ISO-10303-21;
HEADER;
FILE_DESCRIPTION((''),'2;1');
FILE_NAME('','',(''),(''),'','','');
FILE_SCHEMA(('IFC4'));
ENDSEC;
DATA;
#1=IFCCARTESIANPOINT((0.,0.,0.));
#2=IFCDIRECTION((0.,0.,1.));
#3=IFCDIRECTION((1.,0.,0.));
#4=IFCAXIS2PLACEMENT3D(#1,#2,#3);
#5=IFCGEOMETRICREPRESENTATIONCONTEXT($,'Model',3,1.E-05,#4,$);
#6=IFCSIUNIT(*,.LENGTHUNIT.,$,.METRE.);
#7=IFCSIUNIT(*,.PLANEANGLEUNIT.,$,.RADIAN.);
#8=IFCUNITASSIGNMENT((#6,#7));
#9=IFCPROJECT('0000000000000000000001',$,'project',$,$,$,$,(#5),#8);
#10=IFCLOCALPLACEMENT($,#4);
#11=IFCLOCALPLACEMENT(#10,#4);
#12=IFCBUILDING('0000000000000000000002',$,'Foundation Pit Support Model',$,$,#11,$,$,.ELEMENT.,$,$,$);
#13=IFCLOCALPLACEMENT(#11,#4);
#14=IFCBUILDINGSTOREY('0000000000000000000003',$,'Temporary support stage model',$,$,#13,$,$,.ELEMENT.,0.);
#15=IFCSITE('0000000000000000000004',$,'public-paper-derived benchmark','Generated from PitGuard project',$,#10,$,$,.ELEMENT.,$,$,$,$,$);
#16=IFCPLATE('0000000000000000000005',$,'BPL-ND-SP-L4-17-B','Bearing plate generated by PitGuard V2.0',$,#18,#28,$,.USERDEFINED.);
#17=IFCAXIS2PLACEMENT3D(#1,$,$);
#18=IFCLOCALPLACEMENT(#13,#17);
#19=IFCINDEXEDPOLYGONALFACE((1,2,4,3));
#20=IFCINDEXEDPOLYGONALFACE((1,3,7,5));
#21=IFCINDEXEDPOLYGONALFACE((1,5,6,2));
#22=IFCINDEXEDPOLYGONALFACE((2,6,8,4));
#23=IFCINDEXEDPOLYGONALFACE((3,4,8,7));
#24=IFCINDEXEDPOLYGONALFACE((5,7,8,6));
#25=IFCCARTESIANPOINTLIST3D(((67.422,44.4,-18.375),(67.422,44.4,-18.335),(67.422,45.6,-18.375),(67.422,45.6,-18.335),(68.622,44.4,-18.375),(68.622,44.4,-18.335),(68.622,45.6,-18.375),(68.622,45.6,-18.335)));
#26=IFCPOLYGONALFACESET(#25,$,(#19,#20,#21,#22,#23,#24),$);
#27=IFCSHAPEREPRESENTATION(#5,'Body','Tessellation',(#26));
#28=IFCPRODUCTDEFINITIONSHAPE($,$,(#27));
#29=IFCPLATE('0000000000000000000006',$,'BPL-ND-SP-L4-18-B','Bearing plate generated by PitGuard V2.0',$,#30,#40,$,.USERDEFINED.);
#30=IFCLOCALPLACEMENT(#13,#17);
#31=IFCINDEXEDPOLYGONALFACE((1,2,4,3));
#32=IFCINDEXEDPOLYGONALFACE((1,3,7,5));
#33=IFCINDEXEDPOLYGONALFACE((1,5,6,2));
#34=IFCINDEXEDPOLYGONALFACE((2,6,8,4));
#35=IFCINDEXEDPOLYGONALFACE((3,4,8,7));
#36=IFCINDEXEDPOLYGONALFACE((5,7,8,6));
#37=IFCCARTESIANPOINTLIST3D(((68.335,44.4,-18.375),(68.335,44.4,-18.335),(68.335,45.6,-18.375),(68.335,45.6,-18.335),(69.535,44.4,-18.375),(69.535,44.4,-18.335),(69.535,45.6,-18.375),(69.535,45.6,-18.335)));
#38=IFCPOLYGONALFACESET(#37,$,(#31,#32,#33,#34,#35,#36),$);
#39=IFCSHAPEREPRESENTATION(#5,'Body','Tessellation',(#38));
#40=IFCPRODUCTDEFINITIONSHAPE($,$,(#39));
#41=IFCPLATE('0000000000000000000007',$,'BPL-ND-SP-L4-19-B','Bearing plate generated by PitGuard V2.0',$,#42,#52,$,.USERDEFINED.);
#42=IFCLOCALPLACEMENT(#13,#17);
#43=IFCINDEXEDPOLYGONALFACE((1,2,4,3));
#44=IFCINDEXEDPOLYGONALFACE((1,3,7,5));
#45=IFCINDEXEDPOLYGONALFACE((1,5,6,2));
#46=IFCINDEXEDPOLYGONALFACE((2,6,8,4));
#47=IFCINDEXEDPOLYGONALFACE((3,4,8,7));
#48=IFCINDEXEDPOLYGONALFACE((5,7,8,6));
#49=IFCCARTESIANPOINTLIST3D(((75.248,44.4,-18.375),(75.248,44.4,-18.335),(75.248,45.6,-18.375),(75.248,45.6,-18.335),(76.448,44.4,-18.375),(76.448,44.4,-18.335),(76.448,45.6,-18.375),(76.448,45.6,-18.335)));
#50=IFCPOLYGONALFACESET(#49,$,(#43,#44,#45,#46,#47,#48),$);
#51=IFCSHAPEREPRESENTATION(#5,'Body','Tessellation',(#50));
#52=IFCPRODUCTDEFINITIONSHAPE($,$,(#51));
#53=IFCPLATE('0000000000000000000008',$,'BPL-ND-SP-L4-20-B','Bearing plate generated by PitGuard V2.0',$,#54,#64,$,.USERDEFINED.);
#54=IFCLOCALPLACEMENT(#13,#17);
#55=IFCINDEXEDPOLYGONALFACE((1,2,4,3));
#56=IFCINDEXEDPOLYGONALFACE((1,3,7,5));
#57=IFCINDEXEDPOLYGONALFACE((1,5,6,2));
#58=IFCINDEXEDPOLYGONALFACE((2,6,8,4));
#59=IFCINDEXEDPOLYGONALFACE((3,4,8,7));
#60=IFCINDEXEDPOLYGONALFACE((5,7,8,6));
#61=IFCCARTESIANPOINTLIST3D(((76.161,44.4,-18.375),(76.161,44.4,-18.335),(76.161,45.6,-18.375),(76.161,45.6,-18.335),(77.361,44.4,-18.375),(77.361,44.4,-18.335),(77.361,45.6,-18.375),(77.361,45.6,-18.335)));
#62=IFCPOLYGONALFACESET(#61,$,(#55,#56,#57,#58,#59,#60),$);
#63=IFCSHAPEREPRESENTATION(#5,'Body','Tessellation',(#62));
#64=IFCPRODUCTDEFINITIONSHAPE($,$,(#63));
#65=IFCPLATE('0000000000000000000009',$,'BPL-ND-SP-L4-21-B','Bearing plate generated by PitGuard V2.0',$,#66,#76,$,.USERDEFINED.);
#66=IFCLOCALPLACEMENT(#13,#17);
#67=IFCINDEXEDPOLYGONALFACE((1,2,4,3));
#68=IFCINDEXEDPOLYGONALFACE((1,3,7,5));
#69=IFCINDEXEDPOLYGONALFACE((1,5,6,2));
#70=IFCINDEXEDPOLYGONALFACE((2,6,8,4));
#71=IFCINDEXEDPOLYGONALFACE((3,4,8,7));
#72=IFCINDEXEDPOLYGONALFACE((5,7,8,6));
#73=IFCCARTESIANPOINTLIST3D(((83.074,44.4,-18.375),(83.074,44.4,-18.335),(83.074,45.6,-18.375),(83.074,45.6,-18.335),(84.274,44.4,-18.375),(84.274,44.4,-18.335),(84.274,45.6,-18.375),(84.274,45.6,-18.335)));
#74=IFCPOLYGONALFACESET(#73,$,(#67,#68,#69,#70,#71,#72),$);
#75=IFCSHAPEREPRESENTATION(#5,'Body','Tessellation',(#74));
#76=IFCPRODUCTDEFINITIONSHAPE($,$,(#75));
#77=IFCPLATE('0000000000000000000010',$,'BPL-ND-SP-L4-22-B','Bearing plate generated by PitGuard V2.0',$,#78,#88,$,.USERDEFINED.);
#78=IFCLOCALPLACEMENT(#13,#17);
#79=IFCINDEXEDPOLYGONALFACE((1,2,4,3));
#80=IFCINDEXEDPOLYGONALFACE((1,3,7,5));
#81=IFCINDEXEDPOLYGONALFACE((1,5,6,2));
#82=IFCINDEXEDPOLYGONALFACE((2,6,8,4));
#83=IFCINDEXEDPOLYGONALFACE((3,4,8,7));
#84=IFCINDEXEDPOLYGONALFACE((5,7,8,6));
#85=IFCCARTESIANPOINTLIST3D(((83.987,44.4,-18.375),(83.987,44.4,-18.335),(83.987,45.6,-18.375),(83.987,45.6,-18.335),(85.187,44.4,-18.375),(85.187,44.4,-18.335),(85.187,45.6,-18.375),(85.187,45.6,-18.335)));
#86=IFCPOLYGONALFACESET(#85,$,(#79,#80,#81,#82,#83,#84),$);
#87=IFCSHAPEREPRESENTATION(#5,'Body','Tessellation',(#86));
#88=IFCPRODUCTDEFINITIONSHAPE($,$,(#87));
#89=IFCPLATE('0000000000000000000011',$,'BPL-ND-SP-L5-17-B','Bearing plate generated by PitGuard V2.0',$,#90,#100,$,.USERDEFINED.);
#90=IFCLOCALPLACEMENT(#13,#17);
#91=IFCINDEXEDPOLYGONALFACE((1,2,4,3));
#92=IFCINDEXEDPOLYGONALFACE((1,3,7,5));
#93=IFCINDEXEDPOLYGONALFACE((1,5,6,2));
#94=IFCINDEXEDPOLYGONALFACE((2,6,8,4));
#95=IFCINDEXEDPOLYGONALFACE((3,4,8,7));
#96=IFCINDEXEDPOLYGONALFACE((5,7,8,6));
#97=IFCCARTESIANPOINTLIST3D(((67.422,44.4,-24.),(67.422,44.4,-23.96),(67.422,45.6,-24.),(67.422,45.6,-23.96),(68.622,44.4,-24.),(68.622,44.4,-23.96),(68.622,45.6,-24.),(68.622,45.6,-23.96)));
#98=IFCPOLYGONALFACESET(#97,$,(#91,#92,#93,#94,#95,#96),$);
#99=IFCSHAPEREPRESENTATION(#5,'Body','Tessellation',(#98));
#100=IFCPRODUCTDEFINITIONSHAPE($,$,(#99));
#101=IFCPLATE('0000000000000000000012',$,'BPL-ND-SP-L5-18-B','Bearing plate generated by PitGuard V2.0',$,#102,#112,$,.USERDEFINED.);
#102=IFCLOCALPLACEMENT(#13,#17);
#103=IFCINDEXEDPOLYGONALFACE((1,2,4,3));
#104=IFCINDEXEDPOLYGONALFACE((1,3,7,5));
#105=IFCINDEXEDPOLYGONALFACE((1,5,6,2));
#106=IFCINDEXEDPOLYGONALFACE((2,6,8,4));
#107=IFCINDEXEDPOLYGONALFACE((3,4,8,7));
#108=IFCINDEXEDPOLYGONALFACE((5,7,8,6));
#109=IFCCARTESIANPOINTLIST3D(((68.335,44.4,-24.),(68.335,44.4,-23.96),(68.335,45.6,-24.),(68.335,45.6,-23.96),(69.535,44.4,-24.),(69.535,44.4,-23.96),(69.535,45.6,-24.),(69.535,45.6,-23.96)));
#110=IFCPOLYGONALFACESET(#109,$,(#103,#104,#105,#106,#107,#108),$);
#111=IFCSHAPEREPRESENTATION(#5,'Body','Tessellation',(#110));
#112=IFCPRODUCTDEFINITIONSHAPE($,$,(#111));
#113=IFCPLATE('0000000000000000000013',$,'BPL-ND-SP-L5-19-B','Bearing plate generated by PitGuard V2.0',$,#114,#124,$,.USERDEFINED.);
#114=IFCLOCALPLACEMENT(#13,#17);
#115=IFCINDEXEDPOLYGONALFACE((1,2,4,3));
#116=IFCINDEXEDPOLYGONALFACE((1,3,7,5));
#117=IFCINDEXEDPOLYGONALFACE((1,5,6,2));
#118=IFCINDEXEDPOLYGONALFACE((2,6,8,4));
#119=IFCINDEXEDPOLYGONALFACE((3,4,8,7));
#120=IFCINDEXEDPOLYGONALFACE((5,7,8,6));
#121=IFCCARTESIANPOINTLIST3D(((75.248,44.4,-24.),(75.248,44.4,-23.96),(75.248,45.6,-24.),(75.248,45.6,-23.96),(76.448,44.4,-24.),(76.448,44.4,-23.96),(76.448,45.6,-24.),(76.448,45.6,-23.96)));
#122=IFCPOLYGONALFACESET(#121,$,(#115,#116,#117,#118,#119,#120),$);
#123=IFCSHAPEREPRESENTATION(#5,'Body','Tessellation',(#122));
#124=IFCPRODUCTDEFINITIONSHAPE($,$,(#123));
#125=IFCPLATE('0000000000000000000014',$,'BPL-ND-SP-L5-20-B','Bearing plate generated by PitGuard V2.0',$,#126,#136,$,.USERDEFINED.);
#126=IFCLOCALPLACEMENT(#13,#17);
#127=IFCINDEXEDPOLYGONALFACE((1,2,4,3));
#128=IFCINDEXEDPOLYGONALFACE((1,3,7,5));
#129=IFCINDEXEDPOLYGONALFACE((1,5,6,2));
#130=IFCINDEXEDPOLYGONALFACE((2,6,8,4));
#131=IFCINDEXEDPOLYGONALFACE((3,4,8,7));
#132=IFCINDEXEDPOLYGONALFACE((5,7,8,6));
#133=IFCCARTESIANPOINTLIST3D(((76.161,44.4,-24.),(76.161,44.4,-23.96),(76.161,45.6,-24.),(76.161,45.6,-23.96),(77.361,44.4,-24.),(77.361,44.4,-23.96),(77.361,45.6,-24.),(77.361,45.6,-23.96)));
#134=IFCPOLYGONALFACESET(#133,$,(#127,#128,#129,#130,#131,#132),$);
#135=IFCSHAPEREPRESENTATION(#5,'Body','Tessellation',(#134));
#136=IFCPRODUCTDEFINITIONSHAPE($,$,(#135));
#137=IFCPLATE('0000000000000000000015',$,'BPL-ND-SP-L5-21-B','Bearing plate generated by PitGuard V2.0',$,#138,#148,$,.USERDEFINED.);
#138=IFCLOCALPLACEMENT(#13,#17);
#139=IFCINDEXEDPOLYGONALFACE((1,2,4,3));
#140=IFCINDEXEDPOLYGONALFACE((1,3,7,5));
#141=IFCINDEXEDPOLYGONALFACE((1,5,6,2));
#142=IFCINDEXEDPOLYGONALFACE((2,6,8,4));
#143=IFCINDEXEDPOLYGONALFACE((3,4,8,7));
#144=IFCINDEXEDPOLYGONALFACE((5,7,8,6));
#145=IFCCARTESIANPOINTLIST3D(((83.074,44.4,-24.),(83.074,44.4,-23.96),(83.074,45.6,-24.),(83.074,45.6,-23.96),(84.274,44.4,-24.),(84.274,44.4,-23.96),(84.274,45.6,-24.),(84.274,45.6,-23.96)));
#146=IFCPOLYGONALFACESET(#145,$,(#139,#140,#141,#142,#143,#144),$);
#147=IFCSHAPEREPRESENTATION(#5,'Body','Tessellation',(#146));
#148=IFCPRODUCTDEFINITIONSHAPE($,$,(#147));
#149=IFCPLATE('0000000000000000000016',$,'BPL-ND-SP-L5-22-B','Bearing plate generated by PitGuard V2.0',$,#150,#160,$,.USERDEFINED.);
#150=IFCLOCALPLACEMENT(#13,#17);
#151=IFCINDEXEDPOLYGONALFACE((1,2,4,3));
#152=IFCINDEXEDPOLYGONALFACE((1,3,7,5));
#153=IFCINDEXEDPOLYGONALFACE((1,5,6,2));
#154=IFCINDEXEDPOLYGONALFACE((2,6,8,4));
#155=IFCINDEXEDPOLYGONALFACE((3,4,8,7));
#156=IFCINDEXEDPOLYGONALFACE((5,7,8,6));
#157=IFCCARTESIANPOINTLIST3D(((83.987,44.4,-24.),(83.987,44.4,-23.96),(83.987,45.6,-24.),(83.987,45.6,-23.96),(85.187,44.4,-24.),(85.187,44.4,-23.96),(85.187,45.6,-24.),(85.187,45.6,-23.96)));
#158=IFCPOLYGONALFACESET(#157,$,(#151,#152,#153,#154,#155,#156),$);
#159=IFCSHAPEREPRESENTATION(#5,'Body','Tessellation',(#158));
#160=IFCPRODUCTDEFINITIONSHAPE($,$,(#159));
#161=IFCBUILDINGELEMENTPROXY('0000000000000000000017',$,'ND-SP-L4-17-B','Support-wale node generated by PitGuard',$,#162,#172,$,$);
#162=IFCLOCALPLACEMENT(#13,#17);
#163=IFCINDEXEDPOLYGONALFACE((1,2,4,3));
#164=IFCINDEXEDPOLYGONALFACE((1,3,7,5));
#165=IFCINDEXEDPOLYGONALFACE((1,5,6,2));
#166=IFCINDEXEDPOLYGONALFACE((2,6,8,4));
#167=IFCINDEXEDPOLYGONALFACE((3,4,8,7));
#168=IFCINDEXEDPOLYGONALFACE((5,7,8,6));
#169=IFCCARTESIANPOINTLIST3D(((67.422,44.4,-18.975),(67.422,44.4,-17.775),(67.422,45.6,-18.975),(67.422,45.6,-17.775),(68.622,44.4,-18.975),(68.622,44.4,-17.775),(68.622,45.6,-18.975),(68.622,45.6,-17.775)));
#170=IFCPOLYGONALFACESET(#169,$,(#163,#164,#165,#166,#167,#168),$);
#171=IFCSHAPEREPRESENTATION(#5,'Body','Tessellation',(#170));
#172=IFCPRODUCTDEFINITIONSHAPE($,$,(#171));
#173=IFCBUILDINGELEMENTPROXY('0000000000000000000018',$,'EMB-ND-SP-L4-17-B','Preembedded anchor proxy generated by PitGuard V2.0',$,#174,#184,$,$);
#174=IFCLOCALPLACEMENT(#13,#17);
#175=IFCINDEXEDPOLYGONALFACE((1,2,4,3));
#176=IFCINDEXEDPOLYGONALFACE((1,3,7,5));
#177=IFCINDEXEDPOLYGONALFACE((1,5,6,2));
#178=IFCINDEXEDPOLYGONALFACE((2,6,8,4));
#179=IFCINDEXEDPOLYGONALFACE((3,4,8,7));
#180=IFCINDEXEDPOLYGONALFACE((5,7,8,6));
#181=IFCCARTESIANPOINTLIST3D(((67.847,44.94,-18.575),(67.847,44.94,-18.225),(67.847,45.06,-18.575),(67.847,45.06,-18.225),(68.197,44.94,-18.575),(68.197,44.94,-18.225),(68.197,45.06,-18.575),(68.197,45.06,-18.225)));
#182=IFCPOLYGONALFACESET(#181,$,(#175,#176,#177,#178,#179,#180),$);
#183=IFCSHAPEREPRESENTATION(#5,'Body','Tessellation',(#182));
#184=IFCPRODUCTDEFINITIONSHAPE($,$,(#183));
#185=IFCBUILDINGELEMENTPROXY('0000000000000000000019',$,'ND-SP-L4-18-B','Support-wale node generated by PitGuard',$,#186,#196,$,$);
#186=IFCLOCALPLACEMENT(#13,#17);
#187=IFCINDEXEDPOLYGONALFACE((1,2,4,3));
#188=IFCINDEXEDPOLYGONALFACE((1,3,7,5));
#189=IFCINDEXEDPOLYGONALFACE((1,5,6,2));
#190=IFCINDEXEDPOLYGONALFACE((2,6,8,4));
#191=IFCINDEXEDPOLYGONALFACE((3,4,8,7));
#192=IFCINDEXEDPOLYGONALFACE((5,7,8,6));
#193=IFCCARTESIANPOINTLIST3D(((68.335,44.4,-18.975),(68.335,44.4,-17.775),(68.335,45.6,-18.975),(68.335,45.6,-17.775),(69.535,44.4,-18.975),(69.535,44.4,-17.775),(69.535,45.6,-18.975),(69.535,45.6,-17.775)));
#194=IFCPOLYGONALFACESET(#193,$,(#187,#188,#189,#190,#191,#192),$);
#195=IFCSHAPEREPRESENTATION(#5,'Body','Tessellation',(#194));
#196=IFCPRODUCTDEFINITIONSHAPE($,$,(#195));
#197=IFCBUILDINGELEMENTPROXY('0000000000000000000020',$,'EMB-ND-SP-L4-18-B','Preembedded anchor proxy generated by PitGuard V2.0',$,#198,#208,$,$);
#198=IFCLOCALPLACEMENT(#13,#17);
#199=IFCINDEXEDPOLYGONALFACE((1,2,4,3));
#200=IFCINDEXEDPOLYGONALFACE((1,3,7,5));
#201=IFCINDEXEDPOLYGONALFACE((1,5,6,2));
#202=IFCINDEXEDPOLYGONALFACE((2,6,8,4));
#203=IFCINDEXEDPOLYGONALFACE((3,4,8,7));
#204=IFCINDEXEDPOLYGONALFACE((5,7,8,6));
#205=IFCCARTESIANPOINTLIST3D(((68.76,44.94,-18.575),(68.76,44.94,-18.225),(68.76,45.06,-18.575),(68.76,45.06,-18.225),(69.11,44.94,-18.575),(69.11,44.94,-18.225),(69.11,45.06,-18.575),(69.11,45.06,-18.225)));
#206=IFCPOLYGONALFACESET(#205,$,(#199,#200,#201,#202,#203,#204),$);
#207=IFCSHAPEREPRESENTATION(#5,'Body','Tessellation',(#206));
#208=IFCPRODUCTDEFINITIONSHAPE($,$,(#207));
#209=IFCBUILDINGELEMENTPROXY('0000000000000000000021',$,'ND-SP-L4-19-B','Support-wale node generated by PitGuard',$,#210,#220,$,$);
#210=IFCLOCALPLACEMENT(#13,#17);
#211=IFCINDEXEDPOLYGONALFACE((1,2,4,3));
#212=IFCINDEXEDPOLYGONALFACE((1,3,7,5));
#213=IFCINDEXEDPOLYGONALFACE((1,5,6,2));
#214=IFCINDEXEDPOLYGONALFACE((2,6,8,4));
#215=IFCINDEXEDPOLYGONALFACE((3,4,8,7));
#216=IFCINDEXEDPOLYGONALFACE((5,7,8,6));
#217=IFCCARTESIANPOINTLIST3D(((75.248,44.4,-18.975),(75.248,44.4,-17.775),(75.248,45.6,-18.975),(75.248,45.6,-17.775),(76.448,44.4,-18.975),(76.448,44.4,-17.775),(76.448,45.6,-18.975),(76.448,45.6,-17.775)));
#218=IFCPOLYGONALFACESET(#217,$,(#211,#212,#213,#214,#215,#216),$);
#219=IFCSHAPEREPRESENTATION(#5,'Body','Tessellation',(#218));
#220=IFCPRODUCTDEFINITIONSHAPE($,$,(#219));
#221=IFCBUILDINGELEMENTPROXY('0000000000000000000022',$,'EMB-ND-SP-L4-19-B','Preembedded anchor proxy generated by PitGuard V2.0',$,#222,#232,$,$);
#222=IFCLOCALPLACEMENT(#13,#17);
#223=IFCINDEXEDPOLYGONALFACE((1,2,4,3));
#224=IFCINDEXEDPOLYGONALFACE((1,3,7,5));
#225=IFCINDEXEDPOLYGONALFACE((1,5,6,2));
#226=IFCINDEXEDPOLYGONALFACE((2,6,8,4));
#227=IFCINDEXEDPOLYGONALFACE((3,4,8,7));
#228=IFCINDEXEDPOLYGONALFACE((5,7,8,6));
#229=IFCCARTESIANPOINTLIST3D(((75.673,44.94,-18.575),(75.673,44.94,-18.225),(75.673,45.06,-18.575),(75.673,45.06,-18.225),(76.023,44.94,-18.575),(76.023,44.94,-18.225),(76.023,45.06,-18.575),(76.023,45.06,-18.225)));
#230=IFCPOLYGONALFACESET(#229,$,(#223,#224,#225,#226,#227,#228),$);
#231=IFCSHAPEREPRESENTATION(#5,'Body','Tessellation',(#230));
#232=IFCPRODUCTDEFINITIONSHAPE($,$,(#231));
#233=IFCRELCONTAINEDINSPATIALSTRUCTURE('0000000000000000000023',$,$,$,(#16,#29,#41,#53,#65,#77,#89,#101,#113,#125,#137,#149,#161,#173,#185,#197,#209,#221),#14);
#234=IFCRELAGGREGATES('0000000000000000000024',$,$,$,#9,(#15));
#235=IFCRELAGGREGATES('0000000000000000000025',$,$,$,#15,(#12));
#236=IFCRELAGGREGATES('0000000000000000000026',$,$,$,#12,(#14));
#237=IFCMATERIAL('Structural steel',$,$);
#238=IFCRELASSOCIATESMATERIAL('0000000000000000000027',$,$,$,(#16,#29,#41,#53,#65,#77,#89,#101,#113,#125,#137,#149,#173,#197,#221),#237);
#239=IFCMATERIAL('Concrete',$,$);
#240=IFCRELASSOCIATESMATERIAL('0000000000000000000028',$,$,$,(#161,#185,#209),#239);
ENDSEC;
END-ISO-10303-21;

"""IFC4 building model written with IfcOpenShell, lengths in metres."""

from ifc_helpers import new_model, si_unit, frame, origin_with_axes, origin_2d, place, context, project, spatial, rectangle, extrude, material, element, save


model = new_model("IFC4")

# Units and contexts
model_context = context("Model", 3, precision=1e-05, world=origin_with_axes())
ifc_project = project(units=[si_unit("LENGTHUNIT", "METRE"), si_unit("PLANEANGLEUNIT", "RADIAN")], contexts=[model_context])

# Site, building, storey
site_placement = place(None, origin_with_axes())
site = spatial("IfcSite", under=ifc_project, at=site_placement, Name="public-paper-derived benchmark", Description="Generated from PitGuard project", CompositionType="ELEMENT")
building_placement = place(site_placement, origin_with_axes())
building = spatial("IfcBuilding", under=site, at=building_placement, Name="Foundation Pit Support Model", CompositionType="ELEMENT")
storey_placement = place(building_placement, origin_with_axes())
storey = spatial("IfcBuildingStorey", under=building, at=storey_placement, Name="Temporary support stage model", CompositionType="ELEMENT", Elevation=0.0)

# Plates
ifc_material_1 = material(Name="Structural steel")
for number, where, z_axis, x_axis, name in (
    (1, (68.022, 45.0, -18.375), (0.0, 0.0, 1.0), (1.0, 0.0, 0.0), "BPL-ND-SP-L4-17-B"),
    (2, (68.935, 45.0, -18.375), (0.0, 0.0, 1.0), (1.0, 0.0, 0.0), "BPL-ND-SP-L4-18-B"),
    (3, (75.848, 45.0, -18.375), (0.0, 0.0, 1.0), (1.0, 0.0, 0.0), "BPL-ND-SP-L4-19-B"),
    (4, (76.761, 45.0, -18.375), (0.0, 0.0, 1.0), (1.0, 0.0, 0.0), "BPL-ND-SP-L4-20-B"),
    (5, (83.674, 45.0, -18.375), (0.0, 0.0, 1.0), (1.0, 0.0, 0.0), "BPL-ND-SP-L4-21-B"),
    (6, (84.587, 45.0, -18.375), (0.0, 0.0, 1.0), (1.0, 0.0, 0.0), "BPL-ND-SP-L4-22-B"),
    (7, (68.022, 45.0, -24.0), (0.0, 0.0, 1.0), (1.0, 0.0, 0.0), "BPL-ND-SP-L5-17-B"),
    (8, (68.935, 45.0, -24.0), (0.0, 0.0, 1.0), (1.0, 0.0, 0.0), "BPL-ND-SP-L5-18-B"),
    (9, (75.848, 45.0, -24.0), (0.0, 0.0, 1.0), (1.0, 0.0, 0.0), "BPL-ND-SP-L5-19-B"),
    (10, (76.761, 45.0, -24.0), (0.0, 0.0, 1.0), (1.0, 0.0, 0.0), "BPL-ND-SP-L5-20-B"),
    (11, (83.674, 45.0, -24.0), (0.0, 0.0, 1.0), (1.0, 0.0, 0.0), "BPL-ND-SP-L5-21-B"),
    (12, (84.587, 45.0, -24.0), (0.0, 0.0, 1.0), (1.0, 0.0, 0.0), "BPL-ND-SP-L5-22-B"),
):
    element("IfcPlate", number, at=place(storey_placement, frame(where, z_axis=z_axis, x_axis=x_axis)), inside=storey, material=ifc_material_1, Name=name, Description="Bearing plate generated by PitGuard V2.0", PredefinedType="USERDEFINED", context=model_context, shape_type="SweptSolid", body=[
        extrude(rectangle(XDim=1.2, YDim=1.2, at=origin_2d()), origin_with_axes(), (0.0, 0.0, 1.0), 0.04),
    ])

# Building element proxies
ifc_material_2 = material(Name="Concrete")
proxy_1_placement = place(storey_placement, frame((68.022, 45.0, -18.975), z_axis=(0.0, 0.0, 1.0), x_axis=(1.0, 0.0, 0.0)))
element("IfcBuildingElementProxy", 13, at=proxy_1_placement, inside=storey, material=ifc_material_2, Name="ND-SP-L4-17-B", Description="Support-wale node generated by PitGuard", context=model_context, shape_type="SweptSolid", body=[
    extrude(rectangle(XDim=1.2, YDim=1.2, at=origin_2d()), origin_with_axes(), (0.0, 0.0, 1.0), 1.2),
])
proxy_2_placement = place(storey_placement, frame((68.022, 45.0, -18.575), z_axis=(0.0, 0.0, 1.0), x_axis=(1.0, 0.0, 0.0)))
element("IfcBuildingElementProxy", 14, at=proxy_2_placement, inside=storey, material=ifc_material_1, Name="EMB-ND-SP-L4-17-B", Description="Preembedded anchor proxy generated by PitGuard V2.0", context=model_context, shape_type="SweptSolid", body=[
    extrude(rectangle(XDim=0.35, YDim=0.12, at=origin_2d()), origin_with_axes(), (0.0, 0.0, 1.0), 0.35),
])
proxy_3_placement = place(storey_placement, frame((68.935, 45.0, -18.975), z_axis=(0.0, 0.0, 1.0), x_axis=(1.0, 0.0, 0.0)))
element("IfcBuildingElementProxy", 15, at=proxy_3_placement, inside=storey, material=ifc_material_2, Name="ND-SP-L4-18-B", Description="Support-wale node generated by PitGuard", context=model_context, shape_type="SweptSolid", body=[
    extrude(rectangle(XDim=1.2, YDim=1.2, at=origin_2d()), origin_with_axes(), (0.0, 0.0, 1.0), 1.2),
])
proxy_4_placement = place(storey_placement, frame((68.935, 45.0, -18.575), z_axis=(0.0, 0.0, 1.0), x_axis=(1.0, 0.0, 0.0)))
element("IfcBuildingElementProxy", 16, at=proxy_4_placement, inside=storey, material=ifc_material_1, Name="EMB-ND-SP-L4-18-B", Description="Preembedded anchor proxy generated by PitGuard V2.0", context=model_context, shape_type="SweptSolid", body=[
    extrude(rectangle(XDim=0.35, YDim=0.12, at=origin_2d()), origin_with_axes(), (0.0, 0.0, 1.0), 0.35),
])
proxy_5_placement = place(storey_placement, frame((75.848, 45.0, -18.975), z_axis=(0.0, 0.0, 1.0), x_axis=(1.0, 0.0, 0.0)))
element("IfcBuildingElementProxy", 17, at=proxy_5_placement, inside=storey, material=ifc_material_2, Name="ND-SP-L4-19-B", Description="Support-wale node generated by PitGuard", context=model_context, shape_type="SweptSolid", body=[
    extrude(rectangle(XDim=1.2, YDim=1.2, at=origin_2d()), origin_with_axes(), (0.0, 0.0, 1.0), 1.2),
])
proxy_6_placement = place(storey_placement, frame((75.848, 45.0, -18.575), z_axis=(0.0, 0.0, 1.0), x_axis=(1.0, 0.0, 0.0)))
element("IfcBuildingElementProxy", 18, at=proxy_6_placement, inside=storey, material=ifc_material_1, Name="EMB-ND-SP-L4-19-B", Description="Preembedded anchor proxy generated by PitGuard V2.0", context=model_context, shape_type="SweptSolid", body=[
    extrude(rectangle(XDim=0.35, YDim=0.12, at=origin_2d()), origin_with_axes(), (0.0, 0.0, 1.0), 0.35),
])

save(model, "model.ifc")
